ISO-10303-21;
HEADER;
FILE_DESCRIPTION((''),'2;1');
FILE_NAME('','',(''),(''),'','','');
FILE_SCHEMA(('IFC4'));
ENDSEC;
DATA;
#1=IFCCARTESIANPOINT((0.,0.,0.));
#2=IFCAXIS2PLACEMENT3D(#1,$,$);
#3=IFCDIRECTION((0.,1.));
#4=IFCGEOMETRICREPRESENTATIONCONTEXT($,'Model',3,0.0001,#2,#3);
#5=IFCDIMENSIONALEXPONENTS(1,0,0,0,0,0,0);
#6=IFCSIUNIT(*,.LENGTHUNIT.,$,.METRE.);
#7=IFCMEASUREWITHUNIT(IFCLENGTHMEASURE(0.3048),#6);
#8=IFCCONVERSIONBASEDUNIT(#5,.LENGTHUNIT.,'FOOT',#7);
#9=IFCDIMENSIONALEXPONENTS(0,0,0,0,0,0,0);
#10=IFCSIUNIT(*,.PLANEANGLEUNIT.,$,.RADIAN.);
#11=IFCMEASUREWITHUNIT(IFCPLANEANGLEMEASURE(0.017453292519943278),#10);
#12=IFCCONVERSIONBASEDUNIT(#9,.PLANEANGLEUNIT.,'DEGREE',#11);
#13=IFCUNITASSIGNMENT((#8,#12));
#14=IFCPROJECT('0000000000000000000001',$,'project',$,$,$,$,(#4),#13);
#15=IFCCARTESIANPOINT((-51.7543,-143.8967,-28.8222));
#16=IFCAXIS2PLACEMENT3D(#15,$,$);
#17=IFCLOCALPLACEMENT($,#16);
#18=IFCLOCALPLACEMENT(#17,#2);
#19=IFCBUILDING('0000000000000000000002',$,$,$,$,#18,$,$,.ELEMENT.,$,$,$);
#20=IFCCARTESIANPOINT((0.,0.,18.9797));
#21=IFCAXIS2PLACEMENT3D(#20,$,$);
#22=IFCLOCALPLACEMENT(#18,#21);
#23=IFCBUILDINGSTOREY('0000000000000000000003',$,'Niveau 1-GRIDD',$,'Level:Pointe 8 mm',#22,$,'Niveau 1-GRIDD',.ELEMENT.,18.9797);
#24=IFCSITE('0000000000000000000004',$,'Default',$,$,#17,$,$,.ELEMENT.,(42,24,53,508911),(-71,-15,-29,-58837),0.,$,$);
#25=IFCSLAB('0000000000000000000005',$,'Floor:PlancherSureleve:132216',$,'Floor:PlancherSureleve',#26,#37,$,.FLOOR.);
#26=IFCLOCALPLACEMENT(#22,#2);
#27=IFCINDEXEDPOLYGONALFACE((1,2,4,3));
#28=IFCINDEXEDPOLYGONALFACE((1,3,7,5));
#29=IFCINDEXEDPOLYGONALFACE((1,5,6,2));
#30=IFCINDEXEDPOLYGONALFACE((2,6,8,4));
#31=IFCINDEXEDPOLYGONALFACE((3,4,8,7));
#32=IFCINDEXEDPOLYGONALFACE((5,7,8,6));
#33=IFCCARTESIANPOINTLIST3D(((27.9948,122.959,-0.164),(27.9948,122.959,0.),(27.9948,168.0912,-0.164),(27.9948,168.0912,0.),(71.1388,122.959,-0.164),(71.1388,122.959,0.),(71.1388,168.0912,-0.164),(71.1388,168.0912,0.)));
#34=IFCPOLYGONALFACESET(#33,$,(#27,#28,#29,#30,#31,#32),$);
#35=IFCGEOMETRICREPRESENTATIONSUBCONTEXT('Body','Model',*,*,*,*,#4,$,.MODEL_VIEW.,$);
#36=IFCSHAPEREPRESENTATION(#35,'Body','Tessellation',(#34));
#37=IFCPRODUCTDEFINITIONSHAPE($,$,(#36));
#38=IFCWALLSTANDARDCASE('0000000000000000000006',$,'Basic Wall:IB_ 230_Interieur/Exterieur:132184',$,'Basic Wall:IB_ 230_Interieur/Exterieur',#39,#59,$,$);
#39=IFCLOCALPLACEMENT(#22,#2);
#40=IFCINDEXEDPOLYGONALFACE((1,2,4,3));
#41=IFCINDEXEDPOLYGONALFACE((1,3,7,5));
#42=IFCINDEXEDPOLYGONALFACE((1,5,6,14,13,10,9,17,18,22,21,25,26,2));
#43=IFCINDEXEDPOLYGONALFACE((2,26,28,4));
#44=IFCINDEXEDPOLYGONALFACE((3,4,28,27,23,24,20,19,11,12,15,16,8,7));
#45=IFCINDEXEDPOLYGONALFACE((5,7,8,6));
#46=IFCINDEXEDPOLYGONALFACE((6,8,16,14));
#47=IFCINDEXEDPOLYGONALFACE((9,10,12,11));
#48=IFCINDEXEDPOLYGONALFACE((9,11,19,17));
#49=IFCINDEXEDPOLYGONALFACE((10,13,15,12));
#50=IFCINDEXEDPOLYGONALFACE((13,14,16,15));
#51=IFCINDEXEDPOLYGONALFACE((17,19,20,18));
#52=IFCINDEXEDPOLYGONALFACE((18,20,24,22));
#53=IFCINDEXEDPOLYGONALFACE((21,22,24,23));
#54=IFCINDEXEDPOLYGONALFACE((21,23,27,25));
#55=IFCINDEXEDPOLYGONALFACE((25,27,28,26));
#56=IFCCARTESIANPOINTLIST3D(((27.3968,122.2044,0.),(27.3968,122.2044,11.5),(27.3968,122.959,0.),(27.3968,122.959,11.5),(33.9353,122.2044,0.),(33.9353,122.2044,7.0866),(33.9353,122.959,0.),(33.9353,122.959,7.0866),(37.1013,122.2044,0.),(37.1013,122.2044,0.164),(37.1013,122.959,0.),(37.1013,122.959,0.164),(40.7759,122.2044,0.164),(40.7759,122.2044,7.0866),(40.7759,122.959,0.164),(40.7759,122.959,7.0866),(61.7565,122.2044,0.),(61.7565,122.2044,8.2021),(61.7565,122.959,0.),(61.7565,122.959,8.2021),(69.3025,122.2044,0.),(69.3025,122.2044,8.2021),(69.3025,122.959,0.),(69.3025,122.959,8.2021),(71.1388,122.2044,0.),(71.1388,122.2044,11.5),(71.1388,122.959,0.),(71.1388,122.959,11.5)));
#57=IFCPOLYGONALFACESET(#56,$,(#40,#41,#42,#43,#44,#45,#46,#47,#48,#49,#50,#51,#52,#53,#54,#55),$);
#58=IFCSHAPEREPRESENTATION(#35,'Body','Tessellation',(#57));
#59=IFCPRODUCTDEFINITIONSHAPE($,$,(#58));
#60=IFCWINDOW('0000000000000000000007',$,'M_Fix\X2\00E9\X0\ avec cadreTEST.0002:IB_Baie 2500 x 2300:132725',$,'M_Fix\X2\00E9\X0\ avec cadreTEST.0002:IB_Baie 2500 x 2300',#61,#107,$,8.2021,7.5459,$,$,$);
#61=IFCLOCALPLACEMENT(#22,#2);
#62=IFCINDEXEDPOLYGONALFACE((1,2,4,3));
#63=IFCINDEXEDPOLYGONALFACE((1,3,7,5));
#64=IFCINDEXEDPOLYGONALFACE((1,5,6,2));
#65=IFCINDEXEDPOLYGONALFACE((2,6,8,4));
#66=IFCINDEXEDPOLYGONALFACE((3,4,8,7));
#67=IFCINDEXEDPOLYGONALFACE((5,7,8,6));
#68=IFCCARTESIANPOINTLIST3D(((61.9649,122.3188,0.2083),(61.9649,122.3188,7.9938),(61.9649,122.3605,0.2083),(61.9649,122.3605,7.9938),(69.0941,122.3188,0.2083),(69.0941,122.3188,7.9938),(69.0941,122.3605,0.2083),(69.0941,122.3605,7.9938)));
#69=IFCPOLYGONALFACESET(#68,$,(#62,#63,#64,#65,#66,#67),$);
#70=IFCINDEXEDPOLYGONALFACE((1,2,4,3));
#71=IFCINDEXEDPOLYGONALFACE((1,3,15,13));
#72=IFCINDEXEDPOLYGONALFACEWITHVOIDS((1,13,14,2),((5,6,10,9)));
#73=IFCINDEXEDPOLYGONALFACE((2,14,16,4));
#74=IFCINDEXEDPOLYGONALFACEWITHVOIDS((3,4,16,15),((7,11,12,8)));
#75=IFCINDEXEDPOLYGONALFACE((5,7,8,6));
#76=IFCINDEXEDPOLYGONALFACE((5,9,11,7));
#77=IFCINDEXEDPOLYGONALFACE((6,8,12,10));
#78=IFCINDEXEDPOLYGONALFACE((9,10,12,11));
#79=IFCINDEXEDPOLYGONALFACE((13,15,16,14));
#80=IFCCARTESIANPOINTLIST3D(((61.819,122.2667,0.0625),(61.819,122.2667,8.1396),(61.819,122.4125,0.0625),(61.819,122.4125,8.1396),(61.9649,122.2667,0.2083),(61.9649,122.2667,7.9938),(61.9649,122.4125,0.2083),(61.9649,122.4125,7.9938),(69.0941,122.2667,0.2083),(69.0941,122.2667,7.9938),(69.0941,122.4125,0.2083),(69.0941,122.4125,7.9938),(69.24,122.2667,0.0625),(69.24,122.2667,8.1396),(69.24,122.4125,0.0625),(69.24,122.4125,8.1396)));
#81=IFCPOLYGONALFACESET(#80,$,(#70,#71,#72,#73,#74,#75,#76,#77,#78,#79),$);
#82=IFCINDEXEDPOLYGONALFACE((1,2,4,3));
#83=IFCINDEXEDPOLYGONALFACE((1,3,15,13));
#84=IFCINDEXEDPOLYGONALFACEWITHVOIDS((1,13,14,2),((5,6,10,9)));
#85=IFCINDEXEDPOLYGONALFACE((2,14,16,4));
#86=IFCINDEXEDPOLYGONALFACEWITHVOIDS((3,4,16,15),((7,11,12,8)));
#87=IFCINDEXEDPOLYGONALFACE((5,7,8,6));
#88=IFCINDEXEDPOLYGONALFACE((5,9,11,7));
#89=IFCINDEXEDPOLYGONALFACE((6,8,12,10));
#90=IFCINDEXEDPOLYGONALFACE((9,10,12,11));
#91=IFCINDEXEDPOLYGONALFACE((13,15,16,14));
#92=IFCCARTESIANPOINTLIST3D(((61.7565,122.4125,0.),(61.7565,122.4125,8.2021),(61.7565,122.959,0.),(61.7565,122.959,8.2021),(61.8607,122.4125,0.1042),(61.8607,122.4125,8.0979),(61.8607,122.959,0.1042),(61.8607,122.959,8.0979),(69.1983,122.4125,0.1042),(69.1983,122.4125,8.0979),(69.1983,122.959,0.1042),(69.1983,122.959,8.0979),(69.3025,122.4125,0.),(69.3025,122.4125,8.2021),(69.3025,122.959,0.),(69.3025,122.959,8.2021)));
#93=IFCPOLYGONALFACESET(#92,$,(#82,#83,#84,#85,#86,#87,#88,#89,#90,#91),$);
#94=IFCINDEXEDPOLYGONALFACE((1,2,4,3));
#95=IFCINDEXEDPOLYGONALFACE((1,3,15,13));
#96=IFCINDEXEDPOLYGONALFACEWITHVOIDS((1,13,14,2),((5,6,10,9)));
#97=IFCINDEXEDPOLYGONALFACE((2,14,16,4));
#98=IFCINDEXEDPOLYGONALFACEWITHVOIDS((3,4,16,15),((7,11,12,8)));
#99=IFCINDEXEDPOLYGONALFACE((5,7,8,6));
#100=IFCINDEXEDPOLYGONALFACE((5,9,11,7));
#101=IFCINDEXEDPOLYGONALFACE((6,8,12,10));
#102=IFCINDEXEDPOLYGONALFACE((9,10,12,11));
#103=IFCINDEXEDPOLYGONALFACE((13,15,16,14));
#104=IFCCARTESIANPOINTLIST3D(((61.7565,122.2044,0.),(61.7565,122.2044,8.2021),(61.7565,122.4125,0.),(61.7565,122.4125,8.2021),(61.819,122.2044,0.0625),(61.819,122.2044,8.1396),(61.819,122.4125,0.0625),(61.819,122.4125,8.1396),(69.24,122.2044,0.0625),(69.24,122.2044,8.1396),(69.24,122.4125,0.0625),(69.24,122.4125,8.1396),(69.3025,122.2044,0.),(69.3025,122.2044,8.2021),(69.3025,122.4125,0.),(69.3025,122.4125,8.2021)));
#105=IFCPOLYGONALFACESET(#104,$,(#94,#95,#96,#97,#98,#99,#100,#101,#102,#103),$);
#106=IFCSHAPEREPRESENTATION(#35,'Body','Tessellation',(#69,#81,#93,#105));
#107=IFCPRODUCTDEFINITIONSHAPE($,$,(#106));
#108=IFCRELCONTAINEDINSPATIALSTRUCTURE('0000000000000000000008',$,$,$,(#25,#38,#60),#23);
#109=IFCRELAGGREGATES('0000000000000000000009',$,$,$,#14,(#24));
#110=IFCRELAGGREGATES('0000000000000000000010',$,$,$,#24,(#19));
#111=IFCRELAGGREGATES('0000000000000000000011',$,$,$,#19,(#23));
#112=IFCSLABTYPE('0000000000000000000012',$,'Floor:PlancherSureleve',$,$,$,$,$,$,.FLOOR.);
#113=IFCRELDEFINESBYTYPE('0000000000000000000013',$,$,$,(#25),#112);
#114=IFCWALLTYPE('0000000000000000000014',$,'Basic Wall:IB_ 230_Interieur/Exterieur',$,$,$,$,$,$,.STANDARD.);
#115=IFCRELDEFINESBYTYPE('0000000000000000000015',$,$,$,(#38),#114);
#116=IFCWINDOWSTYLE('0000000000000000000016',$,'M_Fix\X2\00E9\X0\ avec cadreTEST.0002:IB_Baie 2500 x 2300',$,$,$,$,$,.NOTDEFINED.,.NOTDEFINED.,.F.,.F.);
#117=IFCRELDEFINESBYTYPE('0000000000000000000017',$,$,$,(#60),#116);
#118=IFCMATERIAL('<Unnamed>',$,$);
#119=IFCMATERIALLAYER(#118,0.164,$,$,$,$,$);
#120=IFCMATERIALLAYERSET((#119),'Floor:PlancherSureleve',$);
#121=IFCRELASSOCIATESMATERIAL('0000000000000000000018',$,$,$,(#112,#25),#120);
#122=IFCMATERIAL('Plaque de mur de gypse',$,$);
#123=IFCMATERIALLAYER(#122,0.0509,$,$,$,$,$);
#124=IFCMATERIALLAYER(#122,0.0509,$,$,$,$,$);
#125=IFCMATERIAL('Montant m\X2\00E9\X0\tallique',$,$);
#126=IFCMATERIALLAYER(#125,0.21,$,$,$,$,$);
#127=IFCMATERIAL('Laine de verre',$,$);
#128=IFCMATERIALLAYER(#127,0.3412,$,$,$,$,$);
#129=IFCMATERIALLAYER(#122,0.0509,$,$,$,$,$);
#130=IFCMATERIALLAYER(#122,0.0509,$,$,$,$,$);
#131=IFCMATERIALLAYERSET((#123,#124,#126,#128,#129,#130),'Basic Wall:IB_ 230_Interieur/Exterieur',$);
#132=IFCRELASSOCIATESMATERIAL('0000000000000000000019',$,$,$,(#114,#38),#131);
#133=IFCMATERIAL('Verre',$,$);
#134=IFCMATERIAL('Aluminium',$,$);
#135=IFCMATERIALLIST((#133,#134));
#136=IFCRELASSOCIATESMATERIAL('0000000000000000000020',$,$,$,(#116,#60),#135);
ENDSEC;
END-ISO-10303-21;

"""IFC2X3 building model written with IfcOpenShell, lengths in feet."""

from ifc_helpers import new_model, entity, si_unit, converted_unit, direction, frame, frame_2d, origin, place, context, subcontext, project, spatial, polyline, rectangle, outline, extrude, source, transform, mapped, material, material_list, layer, layer_set, layer_usage, type_object, type_shapes, element, fill, save


model = new_model("IFC2X3")

# Units and contexts
model_context = context("Model", 3, precision=0.0001, world=origin(), true_north=direction((0.0, 1.0)))
body_context = subcontext(model_context, "Body", "Model", "MODEL_VIEW")
ifc_project = project(units=[converted_unit("LENGTHUNIT", "FOOT", entity("IfcLengthMeasure", 0.3048), si_unit("LENGTHUNIT", "METRE"), dimensions=[1, 0, 0, 0, 0, 0, 0]), converted_unit("PLANEANGLEUNIT", "DEGREE", entity("IfcPlaneAngleMeasure", 0.017453292519943278), si_unit("PLANEANGLEUNIT", "RADIAN"), dimensions=[0, 0, 0, 0, 0, 0, 0])], contexts=[model_context])

# Site, building, storey
site_placement = place(None, frame((-51.7543, -143.8967, -28.8222)))
site = spatial("IfcSite", under=ifc_project, at=site_placement, Name="Default", CompositionType="ELEMENT", RefLatitude=(42, 24, 53, 508911), RefLongitude=(-71, -15, -29, -58837), RefElevation=0.0)
building_placement = place(site_placement, origin())
building = spatial("IfcBuilding", under=site, at=building_placement, CompositionType="ELEMENT")
storey_placement = place(building_placement, frame((0.0, 0.0, 18.9797)))
storey = spatial("IfcBuildingStorey", under=building, at=storey_placement, Name="Niveau 1-GRIDD", ObjectType="Level:Pointe 8 mm", LongName="Niveau 1-GRIDD", CompositionType="ELEMENT", Elevation=18.9797)

# Slab
ifc_material_1 = material(Name="<Unnamed>")
ifc_layer_1 = layer(ifc_material_1, 0.164)
ifc_layer_set_1 = layer_set([ifc_layer_1], Name="Floor:PlancherSureleve")
ifc_layer_usage_1 = layer_usage(ifc_layer_set_1, "AXIS3", "POSITIVE", 0.0)
slab_type = type_object("IfcSlabType", Name="Floor:PlancherSureleve", PredefinedType="FLOOR", material=ifc_layer_set_1)
slab_placement = place(storey_placement, origin())
element("IfcSlab", 1, at=slab_placement, inside=storey, type_object=slab_type, material=ifc_layer_usage_1, Name="Floor:PlancherSureleve:132216", ObjectType="Floor:PlancherSureleve", PredefinedType="FLOOR", context=body_context, shape_type="SweptSolid", body=[
    extrude(rectangle(XDim=45.1322, YDim=43.144, at=frame_2d((0.0, 0.0), x_axis=(1.0, 0.0))), frame((49.5668, 145.5251, 0.0), z_axis=(0.0, 0.0, -1.0), x_axis=(0.0, 1.0, 0.0)), (0.0, 0.0, 1.0), 0.164),
])

# Wall, openings, window
ifc_material_2 = material(Name="Plaque de mur de gypse")
ifc_layer_2 = layer(ifc_material_2, 0.0509)
ifc_layer_3 = layer(ifc_material_2, 0.0509)
ifc_material_3 = material(Name="Montant métallique")
ifc_layer_4 = layer(ifc_material_3, 0.21)
ifc_material_4 = material(Name="Laine de verre")
ifc_layer_5 = layer(ifc_material_4, 0.3412)
ifc_layer_6 = layer(ifc_material_2, 0.0509)
ifc_layer_7 = layer(ifc_material_2, 0.0509)
ifc_layer_set_2 = layer_set([ifc_layer_2, ifc_layer_3, ifc_layer_4, ifc_layer_5, ifc_layer_6, ifc_layer_7], Name="Basic Wall:IB_ 230_Interieur/Exterieur")
ifc_layer_usage_2 = layer_usage(ifc_layer_set_2, "AXIS2", "NEGATIVE", 0.3773)
wall_type_1 = type_object("IfcWallType", Name="Basic Wall:IB_ 230_Interieur/Exterieur", PredefinedType="STANDARD", material=ifc_layer_set_2)
wall_1_placement = place(storey_placement, frame((71.1388, 122.5817, 0.0), z_axis=(0.0, 0.0, 1.0), x_axis=(-1.0, 0.0, 0.0)))
wall_1 = element("IfcWallStandardCase", 2, at=wall_1_placement, inside=storey, type_object=wall_type_1, material=ifc_layer_usage_2, Name="Basic Wall:IB_ 230_Interieur/Exterieur:132184", ObjectType="Basic Wall:IB_ 230_Interieur/Exterieur", context=body_context, shape_type="SweptSolid", body=[
    extrude(rectangle(XDim=43.742, YDim=0.7546, at=frame_2d((21.871, 0.0), x_axis=(1.0, 0.0))), origin(), (0.0, 0.0, 1.0), 11.5),
])
opening_1_placement = place(wall_1_placement, frame((37.2035, 0.3773, 0.0)))
element("IfcOpeningElement", 3, at=opening_1_placement, cuts=wall_1, ObjectType="Opening", context=body_context, shape_type="SweptSolid", body=[
    extrude(outline(polyline([(0.0, 0.0), (7.0866, 0.0), (7.0866, 6.8406), (0.164, 6.8406), (0.164, 3.166), (0.0, 3.166), (0.0, 0.0)])), frame((0.0, 0.0, 0.0), z_axis=(0.0, -1.0, 0.0), x_axis=(0.0, 0.0, 1.0)), (0.0, 0.0, 1.0), 0.7546),
])
opening_2_placement = place(wall_1_placement, frame((1.8363, -0.3773, 0.0)))
opening_2 = element("IfcOpeningElement", 4, at=opening_2_placement, cuts=wall_1, ObjectType="Opening", context=body_context, shape_type="SweptSolid", body=[
    extrude(rectangle(XDim=8.2021, YDim=7.5459, at=frame_2d((4.101, 3.773), x_axis=(-1.0, 0.0))), frame((0.0, 0.0, 0.0), z_axis=(0.0, 1.0, 0.0), x_axis=(0.0, 0.0, 1.0)), (0.0, 0.0, 1.0), 0.7546),
])
ifc_material_5 = material(Name="Verre")
ifc_material_6 = material(Name="Aluminium")
ifc_material_list = material_list([ifc_material_5, ifc_material_6])
window_style_1 = type_object("IfcWindowStyle", Name="M_Fixé avec cadreTEST.0002:IB_Baie 2500 x 2300", ConstructionType="NOTDEFINED", OperationType="NOTDEFINED", ParameterTakesPrecedence=False, Sizeable=False, material=ifc_material_list)
shared_shape_1 = source(origin(), body_context, "Body", "SweptSolid", [
    extrude(rectangle(XDim=0.0417, YDim=7.1293, at=frame_2d((0.0, 0.0), x_axis=(1.0, 0.0))), frame((3.773, 0.6193, 0.2083), z_axis=(0.0, 0.0, 1.0), x_axis=(0.0, 1.0, 0.0)), (0.0, 0.0, 1.0), 7.7854),
    extrude(outline(polyline([(-3.7105, -4.0385), (3.7105, -4.0385), (3.7105, 4.0385), (-3.7105, 4.0385), (-3.7105, -4.0385)]), holes=[polyline([(-3.5646, -3.8927), (-3.5646, 3.8927), (3.5646, 3.8927), (3.5646, -3.8927), (-3.5646, -3.8927)])]), frame((3.773, 0.5464, 4.101), z_axis=(0.0, 1.0, 0.0), x_axis=(1.0, 0.0, 0.0)), (0.0, 0.0, 1.0), 0.1458),
    extrude(outline(polyline([(-3.773, -4.101), (3.773, -4.101), (3.773, 4.101), (-3.773, 4.101), (-3.773, -4.101)]), holes=[polyline([(-3.6688, -3.9969), (-3.6688, 3.9969), (3.6688, 3.9969), (3.6688, -3.9969), (-3.6688, -3.9969)])]), frame((3.773, 0.0, 4.101), z_axis=(0.0, 1.0, 0.0), x_axis=(1.0, 0.0, 0.0)), (0.0, 0.0, 1.0), 0.5464),
    extrude(outline(polyline([(-4.101, -3.773), (4.101, -3.773), (4.101, 3.773), (-4.101, 3.773), (-4.101, -3.773)]), holes=[polyline([(-4.0385, -3.7105), (-4.0385, 3.7105), (4.0385, 3.7105), (4.0385, -3.7105), (-4.0385, -3.7105)])]), frame((3.773, 0.5464, 4.101), z_axis=(0.0, 1.0, 0.0), x_axis=(0.0, 0.0, -1.0)), (0.0, 0.0, 1.0), 0.2082),
])
type_shapes(window_style_1, [shared_shape_1])
window_1_placement = place(opening_2_placement, origin())
window_1 = element("IfcWindow", 5, at=window_1_placement, inside=storey, type_object=window_style_1, material=ifc_material_list, Name="M_Fixé avec cadreTEST.0002:IB_Baie 2500 x 2300:132725", ObjectType="M_Fixé avec cadreTEST.0002:IB_Baie 2500 x 2300", OverallHeight=8.2021, OverallWidth=7.5459, context=body_context, shape_type="MappedRepresentation", body=[
    mapped(shared_shape_1, transform((0.0, 0.0, 0.0), scale=1.0)),
])
fill(opening_2, window_1)

save(model, "model.ifc")
